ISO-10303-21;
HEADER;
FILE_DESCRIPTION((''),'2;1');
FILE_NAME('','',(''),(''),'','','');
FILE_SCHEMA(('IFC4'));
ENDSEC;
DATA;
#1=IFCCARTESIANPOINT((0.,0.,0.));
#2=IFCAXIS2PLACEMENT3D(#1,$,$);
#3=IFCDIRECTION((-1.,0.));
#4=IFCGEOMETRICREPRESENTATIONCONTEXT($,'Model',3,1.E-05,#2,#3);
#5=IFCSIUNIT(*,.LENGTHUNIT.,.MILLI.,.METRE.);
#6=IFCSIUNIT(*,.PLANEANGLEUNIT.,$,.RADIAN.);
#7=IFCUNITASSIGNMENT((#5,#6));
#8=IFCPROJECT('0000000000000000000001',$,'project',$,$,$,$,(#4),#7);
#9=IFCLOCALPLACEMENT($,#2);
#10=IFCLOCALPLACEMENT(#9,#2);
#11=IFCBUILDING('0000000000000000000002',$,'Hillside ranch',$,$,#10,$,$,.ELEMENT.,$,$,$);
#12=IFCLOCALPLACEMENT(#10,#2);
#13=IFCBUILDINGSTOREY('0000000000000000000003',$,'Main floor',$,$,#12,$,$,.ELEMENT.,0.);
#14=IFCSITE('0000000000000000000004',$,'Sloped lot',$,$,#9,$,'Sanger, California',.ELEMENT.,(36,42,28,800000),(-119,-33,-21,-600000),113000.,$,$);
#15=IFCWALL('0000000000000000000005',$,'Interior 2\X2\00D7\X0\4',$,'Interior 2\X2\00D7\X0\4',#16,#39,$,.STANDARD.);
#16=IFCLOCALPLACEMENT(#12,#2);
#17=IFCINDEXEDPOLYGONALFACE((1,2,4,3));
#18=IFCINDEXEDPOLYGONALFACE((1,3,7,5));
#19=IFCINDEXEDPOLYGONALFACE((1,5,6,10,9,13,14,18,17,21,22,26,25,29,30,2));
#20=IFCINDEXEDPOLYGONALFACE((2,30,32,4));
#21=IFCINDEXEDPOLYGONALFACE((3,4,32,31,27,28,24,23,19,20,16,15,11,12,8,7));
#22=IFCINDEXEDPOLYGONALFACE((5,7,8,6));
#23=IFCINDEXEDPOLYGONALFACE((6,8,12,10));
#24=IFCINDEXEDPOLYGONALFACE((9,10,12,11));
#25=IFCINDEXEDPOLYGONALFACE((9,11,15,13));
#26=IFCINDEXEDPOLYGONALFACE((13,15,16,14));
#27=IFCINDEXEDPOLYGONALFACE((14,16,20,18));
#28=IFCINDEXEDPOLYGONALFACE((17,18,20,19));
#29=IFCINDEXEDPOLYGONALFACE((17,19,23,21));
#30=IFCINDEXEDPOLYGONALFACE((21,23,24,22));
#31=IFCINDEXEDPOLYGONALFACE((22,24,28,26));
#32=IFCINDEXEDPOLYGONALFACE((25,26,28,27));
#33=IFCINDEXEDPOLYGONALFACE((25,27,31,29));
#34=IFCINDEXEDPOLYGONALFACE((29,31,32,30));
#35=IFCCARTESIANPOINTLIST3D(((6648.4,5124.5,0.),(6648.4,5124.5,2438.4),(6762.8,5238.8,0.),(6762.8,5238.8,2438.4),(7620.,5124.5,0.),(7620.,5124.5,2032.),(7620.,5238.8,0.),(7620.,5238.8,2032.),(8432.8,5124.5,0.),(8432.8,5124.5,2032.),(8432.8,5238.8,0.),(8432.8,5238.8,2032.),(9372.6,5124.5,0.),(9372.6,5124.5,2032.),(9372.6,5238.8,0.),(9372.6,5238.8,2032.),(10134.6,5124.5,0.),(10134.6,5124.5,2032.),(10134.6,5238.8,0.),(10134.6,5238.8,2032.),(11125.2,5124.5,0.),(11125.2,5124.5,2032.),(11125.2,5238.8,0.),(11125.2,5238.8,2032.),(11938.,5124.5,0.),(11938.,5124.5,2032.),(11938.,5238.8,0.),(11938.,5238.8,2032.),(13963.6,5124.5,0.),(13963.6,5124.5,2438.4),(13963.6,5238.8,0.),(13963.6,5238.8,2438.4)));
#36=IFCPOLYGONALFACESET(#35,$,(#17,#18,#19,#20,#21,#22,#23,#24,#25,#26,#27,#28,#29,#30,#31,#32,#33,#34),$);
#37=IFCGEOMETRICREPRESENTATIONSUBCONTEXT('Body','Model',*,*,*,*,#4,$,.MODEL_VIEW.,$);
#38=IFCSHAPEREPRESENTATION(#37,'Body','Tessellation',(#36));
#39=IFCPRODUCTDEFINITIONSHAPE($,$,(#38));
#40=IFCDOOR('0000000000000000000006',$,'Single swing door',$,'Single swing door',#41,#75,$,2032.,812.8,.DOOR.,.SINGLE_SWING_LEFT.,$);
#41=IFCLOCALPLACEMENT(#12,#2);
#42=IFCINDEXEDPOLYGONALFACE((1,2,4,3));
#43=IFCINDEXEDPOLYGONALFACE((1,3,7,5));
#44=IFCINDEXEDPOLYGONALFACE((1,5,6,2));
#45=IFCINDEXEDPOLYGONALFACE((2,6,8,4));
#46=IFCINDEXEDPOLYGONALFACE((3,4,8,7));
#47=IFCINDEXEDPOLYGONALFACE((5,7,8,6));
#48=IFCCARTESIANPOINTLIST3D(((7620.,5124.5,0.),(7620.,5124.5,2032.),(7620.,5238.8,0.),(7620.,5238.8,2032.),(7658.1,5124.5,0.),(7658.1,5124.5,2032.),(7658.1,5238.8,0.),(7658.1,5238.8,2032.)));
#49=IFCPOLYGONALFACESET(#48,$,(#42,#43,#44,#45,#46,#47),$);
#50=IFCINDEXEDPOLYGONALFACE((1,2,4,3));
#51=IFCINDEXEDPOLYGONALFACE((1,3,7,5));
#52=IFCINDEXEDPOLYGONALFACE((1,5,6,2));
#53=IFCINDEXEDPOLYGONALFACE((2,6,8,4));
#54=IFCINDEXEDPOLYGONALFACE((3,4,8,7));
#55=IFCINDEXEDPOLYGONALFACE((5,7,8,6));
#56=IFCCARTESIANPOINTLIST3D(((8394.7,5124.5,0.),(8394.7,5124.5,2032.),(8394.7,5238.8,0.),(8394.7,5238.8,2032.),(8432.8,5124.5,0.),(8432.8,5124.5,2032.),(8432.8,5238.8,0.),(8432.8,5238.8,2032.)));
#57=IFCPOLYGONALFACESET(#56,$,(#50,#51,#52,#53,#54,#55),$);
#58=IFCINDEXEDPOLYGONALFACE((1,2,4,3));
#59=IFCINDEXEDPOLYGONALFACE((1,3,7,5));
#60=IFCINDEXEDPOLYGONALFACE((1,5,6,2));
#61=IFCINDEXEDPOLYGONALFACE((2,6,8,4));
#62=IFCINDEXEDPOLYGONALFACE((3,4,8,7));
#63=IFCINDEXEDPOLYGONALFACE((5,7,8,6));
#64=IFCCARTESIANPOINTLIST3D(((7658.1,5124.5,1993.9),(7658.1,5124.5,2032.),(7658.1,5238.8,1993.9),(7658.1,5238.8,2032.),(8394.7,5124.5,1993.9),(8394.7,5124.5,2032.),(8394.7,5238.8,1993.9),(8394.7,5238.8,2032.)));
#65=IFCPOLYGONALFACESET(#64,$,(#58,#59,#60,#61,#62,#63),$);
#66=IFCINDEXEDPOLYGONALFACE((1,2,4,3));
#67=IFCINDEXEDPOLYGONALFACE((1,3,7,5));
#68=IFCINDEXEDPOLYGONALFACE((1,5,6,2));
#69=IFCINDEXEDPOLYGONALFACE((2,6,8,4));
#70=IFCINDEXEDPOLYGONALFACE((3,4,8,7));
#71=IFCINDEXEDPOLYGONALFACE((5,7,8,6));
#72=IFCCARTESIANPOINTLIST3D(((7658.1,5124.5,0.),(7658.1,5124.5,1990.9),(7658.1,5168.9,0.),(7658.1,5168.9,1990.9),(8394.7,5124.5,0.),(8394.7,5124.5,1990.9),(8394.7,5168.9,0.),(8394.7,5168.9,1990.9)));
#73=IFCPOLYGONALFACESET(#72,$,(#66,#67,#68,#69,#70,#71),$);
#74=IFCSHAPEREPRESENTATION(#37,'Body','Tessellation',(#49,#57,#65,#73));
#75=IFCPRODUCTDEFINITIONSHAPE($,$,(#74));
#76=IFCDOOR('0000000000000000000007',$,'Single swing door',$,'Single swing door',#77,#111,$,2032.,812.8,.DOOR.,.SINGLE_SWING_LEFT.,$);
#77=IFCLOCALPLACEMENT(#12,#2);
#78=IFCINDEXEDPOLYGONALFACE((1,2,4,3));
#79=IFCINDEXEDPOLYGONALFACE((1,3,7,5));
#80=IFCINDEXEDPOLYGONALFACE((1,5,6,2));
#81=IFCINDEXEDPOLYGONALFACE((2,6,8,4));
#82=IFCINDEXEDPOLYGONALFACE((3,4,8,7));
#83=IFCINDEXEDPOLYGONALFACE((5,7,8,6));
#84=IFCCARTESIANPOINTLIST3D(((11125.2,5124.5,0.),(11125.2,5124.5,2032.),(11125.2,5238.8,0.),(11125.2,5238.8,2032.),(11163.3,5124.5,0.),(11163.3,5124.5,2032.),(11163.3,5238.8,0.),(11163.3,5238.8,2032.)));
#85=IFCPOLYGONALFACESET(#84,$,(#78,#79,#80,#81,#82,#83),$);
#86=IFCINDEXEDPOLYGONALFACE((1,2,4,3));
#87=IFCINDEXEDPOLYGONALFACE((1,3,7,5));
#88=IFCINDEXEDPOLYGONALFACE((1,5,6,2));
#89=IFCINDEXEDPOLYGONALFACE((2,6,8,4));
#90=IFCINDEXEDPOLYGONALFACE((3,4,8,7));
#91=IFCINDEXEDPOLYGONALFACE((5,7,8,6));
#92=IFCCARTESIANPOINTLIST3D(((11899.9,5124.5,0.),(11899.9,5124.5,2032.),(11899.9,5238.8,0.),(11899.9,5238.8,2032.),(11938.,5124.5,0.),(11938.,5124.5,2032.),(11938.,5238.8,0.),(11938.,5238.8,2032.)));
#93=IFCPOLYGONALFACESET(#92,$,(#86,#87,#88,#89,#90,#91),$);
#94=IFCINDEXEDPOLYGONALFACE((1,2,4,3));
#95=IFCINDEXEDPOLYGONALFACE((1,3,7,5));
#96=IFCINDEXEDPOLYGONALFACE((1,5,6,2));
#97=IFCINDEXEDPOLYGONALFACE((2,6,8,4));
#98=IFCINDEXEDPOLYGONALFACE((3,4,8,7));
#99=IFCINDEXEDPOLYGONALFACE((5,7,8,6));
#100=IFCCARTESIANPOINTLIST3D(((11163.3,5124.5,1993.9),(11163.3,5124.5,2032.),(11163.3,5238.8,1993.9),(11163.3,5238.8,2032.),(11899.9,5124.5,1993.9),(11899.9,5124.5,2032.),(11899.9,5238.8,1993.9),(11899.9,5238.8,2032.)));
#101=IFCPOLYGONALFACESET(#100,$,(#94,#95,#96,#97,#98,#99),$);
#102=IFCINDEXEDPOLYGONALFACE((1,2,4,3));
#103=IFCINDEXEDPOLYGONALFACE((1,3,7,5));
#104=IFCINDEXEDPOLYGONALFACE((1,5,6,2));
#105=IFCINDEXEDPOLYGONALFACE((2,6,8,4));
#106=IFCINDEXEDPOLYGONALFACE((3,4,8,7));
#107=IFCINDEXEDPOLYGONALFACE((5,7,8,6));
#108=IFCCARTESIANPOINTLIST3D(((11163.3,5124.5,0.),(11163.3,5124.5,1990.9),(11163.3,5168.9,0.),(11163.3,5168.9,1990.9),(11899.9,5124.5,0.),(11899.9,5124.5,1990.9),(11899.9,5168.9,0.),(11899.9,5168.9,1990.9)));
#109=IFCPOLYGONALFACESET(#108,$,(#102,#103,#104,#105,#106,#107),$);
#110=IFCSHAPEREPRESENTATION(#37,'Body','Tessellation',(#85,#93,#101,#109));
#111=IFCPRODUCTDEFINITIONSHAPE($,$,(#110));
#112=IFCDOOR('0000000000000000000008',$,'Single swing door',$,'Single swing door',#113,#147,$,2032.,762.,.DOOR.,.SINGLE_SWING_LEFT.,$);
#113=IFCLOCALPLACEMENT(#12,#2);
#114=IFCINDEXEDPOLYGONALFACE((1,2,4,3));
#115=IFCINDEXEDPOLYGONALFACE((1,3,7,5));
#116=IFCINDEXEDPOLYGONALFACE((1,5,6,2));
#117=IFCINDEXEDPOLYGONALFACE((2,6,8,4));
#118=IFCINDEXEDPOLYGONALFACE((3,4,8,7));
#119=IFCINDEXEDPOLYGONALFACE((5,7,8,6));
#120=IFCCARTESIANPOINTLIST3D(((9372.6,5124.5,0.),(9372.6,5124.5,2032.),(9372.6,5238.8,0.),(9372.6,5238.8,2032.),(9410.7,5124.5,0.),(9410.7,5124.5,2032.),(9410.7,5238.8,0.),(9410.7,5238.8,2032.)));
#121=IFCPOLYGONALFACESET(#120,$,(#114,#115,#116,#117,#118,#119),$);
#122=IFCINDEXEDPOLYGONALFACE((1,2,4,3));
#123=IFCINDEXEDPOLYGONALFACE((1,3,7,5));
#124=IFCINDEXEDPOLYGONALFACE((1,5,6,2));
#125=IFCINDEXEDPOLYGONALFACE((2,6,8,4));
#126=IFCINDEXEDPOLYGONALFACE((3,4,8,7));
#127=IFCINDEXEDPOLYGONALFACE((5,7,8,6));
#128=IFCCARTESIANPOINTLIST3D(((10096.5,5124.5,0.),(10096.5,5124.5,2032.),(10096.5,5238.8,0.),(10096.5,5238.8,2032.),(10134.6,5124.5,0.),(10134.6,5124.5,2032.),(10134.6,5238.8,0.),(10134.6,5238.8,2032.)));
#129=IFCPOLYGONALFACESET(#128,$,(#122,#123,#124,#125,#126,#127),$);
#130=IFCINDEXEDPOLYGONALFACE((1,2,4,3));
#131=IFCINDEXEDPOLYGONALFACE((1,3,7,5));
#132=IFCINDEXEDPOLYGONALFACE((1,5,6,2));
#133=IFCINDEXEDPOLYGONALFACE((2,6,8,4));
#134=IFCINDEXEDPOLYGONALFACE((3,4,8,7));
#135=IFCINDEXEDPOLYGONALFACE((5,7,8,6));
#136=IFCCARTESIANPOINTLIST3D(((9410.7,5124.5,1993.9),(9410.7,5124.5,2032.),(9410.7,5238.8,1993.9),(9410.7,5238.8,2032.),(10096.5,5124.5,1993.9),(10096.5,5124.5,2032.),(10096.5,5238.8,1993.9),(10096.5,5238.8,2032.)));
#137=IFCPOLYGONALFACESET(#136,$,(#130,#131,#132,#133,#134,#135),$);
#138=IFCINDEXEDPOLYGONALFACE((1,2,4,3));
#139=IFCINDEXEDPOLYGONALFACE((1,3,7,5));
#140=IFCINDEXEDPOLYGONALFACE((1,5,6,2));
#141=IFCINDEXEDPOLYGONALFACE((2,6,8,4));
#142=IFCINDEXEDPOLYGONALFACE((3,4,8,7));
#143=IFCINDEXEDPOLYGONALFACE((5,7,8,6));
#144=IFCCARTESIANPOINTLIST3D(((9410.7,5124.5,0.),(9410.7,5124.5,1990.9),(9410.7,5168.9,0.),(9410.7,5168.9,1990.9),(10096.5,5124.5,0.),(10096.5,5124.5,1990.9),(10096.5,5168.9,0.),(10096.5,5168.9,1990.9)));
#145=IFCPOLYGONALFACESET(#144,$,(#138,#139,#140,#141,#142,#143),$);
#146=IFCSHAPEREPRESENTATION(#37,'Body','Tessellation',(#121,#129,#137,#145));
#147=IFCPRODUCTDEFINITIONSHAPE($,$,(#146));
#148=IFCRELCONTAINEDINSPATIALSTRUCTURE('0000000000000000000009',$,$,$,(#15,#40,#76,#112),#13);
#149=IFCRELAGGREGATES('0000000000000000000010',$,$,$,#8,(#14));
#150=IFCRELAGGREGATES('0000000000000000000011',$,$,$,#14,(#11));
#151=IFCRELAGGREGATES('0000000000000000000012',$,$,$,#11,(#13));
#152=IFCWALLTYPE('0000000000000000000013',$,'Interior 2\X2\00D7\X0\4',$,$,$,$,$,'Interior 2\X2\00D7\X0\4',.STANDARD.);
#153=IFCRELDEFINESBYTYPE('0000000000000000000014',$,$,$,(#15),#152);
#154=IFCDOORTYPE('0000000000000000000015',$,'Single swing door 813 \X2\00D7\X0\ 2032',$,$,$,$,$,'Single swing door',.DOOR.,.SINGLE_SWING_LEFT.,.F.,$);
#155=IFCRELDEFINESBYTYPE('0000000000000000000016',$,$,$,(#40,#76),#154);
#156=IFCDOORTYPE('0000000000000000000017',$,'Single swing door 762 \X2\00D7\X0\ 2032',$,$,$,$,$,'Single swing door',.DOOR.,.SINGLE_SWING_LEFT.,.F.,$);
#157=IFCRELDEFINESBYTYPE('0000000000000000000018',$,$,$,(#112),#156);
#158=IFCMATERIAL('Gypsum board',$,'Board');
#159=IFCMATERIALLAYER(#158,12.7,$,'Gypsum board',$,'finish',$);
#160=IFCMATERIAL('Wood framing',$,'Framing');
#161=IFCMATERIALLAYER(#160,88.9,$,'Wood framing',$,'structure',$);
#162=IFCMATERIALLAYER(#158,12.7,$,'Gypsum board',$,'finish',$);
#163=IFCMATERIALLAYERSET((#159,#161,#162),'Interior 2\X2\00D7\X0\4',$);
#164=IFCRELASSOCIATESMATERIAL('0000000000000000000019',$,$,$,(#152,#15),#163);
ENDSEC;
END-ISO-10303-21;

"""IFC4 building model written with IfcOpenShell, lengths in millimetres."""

from ifc_helpers import new_model, si_unit, direction, frame, origin, origin_with_axes, place, context, subcontext, project, spatial, polyline, outline, extrude, material, layer, layer_set, layer_usage, type_object, element, fill, save


model = new_model("IFC4")

# Units and contexts
model_context = context("Model", 3, precision=1e-05, world=origin(), true_north=direction((-1.0, 0.0)))
body_context = subcontext(model_context, "Body", "Model", "MODEL_VIEW")
ifc_project = project(units=[si_unit("LENGTHUNIT", "METRE", prefix="MILLI"), si_unit("PLANEANGLEUNIT", "RADIAN")], contexts=[model_context])

# Site, building, storey
site_placement = place(None, origin())
site = spatial("IfcSite", under=ifc_project, at=site_placement, Name="Sloped lot", LongName="Sanger, California", CompositionType="ELEMENT", RefLatitude=(36, 42, 28, 800000), RefLongitude=(-119, -33, -21, -600000), RefElevation=113000.0)
building_placement = place(site_placement, origin())
building = spatial("IfcBuilding", under=site, at=building_placement, Name="Hillside ranch", CompositionType="ELEMENT")
storey_placement = place(building_placement, origin())
storey = spatial("IfcBuildingStorey", under=building, at=storey_placement, Name="Main floor", CompositionType="ELEMENT", Elevation=0.0)

# Wall, openings, doors
ifc_material_1 = material(Name="Gypsum board", Category="Board")
ifc_layer_1 = layer(ifc_material_1, 12.7, Name="Gypsum board", Category="finish")
ifc_material_2 = material(Name="Wood framing", Category="Framing")
ifc_layer_2 = layer(ifc_material_2, 88.9, Name="Wood framing", Category="structure")
ifc_layer_3 = layer(ifc_material_1, 12.7, Name="Gypsum board", Category="finish")
ifc_layer_set = layer_set([ifc_layer_1, ifc_layer_2, ifc_layer_3], Name="Interior 2×4")
ifc_layer_usage_1 = layer_usage(ifc_layer_set, "AXIS2", "NEGATIVE", 57.1)
wall_type = type_object("IfcWallType", Name="Interior 2×4", ElementType="Interior 2×4", PredefinedType="STANDARD", material=ifc_layer_set)
wall_1_placement = place(storey_placement, frame((6705.6, 5181.6, 0.0), z_axis=(0.0, 0.0, 1.0), x_axis=(1.0, 0.0, 0.0)))
wall_1 = element("IfcWall", 1, at=wall_1_placement, inside=storey, type_object=wall_type, material=ifc_layer_usage_1, Name="Interior 2×4", ObjectType="Interior 2×4", PredefinedType="STANDARD", context=body_context, shape_type="SweptSolid", body=[
    extrude(outline(polyline([(-57.1, -57.1), (7258.1, -57.1), (7258.1, 57.1), (57.1, 57.1), (-57.1, -57.1)])), origin(), (0.0, 0.0, 1.0), 2438.4),
])
opening_1_placement = place(wall_1_placement, frame((914.4, 0.0, 0.0), z_axis=(0.0, 0.0, 1.0), x_axis=(1.0, 0.0, 0.0)))
opening_1 = element("IfcOpeningElement", 2, at=opening_1_placement, cuts=wall_1, PredefinedType="OPENING", context=body_context, shape_type="SweptSolid", body=[
    extrude(outline(polyline([(0.0, -67.2), (812.8, -67.2), (812.8, 67.2), (0.0, 67.2), (0.0, -67.2)])), origin(), (0.0, 0.0, 1.0), 2032.0),
])
opening_2_placement = place(wall_1_placement, frame((2667.0, 0.0, 0.0), z_axis=(0.0, 0.0, 1.0), x_axis=(1.0, 0.0, 0.0)))
opening_2 = element("IfcOpeningElement", 3, at=opening_2_placement, cuts=wall_1, PredefinedType="OPENING", context=body_context, shape_type="SweptSolid", body=[
    extrude(outline(polyline([(0.0, -67.2), (762.0, -67.2), (762.0, 67.2), (0.0, 67.2), (0.0, -67.2)])), origin(), (0.0, 0.0, 1.0), 2032.0),
])
opening_3_placement = place(wall_1_placement, frame((4419.6, 0.0, 0.0), z_axis=(0.0, 0.0, 1.0), x_axis=(1.0, 0.0, 0.0)))
opening_3 = element("IfcOpeningElement", 4, at=opening_3_placement, cuts=wall_1, PredefinedType="OPENING", context=body_context, shape_type="SweptSolid", body=[
    extrude(outline(polyline([(0.0, -67.2), (812.8, -67.2), (812.8, 67.2), (0.0, 67.2), (0.0, -67.2)])), origin(), (0.0, 0.0, 1.0), 2032.0),
])
door_type_1 = type_object("IfcDoorType", Name="Single swing door 813 × 2032", ElementType="Single swing door", OperationType="SINGLE_SWING_LEFT", ParameterTakesPrecedence=False, PredefinedType="DOOR")
door_1_placement = place(opening_1_placement, origin_with_axes())
door_1 = element("IfcDoor", 5, at=door_1_placement, inside=storey, type_object=door_type_1, Name="Single swing door", ObjectType="Single swing door", OperationType="SINGLE_SWING_LEFT", OverallHeight=2032.0, OverallWidth=812.8, PredefinedType="DOOR", context=body_context, shape_type="SweptSolid", body=[
    extrude(outline(polyline([(0.0, -57.1), (38.1, -57.1), (38.1, 57.1), (0.0, 57.1), (0.0, -57.1)])), origin(), (0.0, 0.0, 1.0), 2032.0),
    extrude(outline(polyline([(774.7, -57.1), (812.8, -57.1), (812.8, 57.1), (774.7, 57.1), (774.7, -57.1)])), origin(), (0.0, 0.0, 1.0), 2032.0),
    extrude(outline(polyline([(38.1, -57.1), (774.7, -57.1), (774.7, 57.1), (38.1, 57.1), (38.1, -57.1)])), frame((0.0, 0.0, 1993.9)), (0.0, 0.0, 1.0), 38.1),
    extrude(outline(polyline([(38.1, -57.1), (774.7, -57.1), (774.7, -12.7), (38.1, -12.7), (38.1, -57.1)])), origin(), (0.0, 0.0, 1.0), 1990.9),
])
fill(opening_1, door_1)
door_2_placement = place(opening_3_placement, origin_with_axes())
door_2 = element("IfcDoor", 6, at=door_2_placement, inside=storey, type_object=door_type_1, Name="Single swing door", ObjectType="Single swing door", OperationType="SINGLE_SWING_LEFT", OverallHeight=2032.0, OverallWidth=812.8, PredefinedType="DOOR", context=body_context, shape_type="SweptSolid", body=[
    extrude(outline(polyline([(0.0, -57.1), (38.1, -57.1), (38.1, 57.1), (0.0, 57.1), (0.0, -57.1)])), origin(), (0.0, 0.0, 1.0), 2032.0),
    extrude(outline(polyline([(774.7, -57.1), (812.8, -57.1), (812.8, 57.1), (774.7, 57.1), (774.7, -57.1)])), origin(), (0.0, 0.0, 1.0), 2032.0),
    extrude(outline(polyline([(38.1, -57.1), (774.7, -57.1), (774.7, 57.1), (38.1, 57.1), (38.1, -57.1)])), frame((0.0, 0.0, 1993.9)), (0.0, 0.0, 1.0), 38.1),
    extrude(outline(polyline([(38.1, -57.1), (774.7, -57.1), (774.7, -12.7), (38.1, -12.7), (38.1, -57.1)])), origin(), (0.0, 0.0, 1.0), 1990.9),
])
fill(opening_3, door_2)
door_type_2 = type_object("IfcDoorType", Name="Single swing door 762 × 2032", ElementType="Single swing door", OperationType="SINGLE_SWING_LEFT", ParameterTakesPrecedence=False, PredefinedType="DOOR")
door_3_placement = place(opening_2_placement, origin_with_axes())
door_3 = element("IfcDoor", 7, at=door_3_placement, inside=storey, type_object=door_type_2, Name="Single swing door", ObjectType="Single swing door", OperationType="SINGLE_SWING_LEFT", OverallHeight=2032.0, OverallWidth=762.0, PredefinedType="DOOR", context=body_context, shape_type="SweptSolid", body=[
    extrude(outline(polyline([(0.0, -57.1), (38.1, -57.1), (38.1, 57.1), (0.0, 57.1), (0.0, -57.1)])), origin(), (0.0, 0.0, 1.0), 2032.0),
    extrude(outline(polyline([(723.9, -57.1), (762.0, -57.1), (762.0, 57.1), (723.9, 57.1), (723.9, -57.1)])), origin(), (0.0, 0.0, 1.0), 2032.0),
    extrude(outline(polyline([(38.1, -57.1), (723.9, -57.1), (723.9, 57.1), (38.1, 57.1), (38.1, -57.1)])), frame((0.0, 0.0, 1993.9)), (0.0, 0.0, 1.0), 38.1),
    extrude(outline(polyline([(38.1, -57.1), (723.9, -57.1), (723.9, -12.7), (38.1, -12.7), (38.1, -57.1)])), origin(), (0.0, 0.0, 1.0), 1990.9),
])
fill(opening_2, door_3)

save(model, "model.ifc")
